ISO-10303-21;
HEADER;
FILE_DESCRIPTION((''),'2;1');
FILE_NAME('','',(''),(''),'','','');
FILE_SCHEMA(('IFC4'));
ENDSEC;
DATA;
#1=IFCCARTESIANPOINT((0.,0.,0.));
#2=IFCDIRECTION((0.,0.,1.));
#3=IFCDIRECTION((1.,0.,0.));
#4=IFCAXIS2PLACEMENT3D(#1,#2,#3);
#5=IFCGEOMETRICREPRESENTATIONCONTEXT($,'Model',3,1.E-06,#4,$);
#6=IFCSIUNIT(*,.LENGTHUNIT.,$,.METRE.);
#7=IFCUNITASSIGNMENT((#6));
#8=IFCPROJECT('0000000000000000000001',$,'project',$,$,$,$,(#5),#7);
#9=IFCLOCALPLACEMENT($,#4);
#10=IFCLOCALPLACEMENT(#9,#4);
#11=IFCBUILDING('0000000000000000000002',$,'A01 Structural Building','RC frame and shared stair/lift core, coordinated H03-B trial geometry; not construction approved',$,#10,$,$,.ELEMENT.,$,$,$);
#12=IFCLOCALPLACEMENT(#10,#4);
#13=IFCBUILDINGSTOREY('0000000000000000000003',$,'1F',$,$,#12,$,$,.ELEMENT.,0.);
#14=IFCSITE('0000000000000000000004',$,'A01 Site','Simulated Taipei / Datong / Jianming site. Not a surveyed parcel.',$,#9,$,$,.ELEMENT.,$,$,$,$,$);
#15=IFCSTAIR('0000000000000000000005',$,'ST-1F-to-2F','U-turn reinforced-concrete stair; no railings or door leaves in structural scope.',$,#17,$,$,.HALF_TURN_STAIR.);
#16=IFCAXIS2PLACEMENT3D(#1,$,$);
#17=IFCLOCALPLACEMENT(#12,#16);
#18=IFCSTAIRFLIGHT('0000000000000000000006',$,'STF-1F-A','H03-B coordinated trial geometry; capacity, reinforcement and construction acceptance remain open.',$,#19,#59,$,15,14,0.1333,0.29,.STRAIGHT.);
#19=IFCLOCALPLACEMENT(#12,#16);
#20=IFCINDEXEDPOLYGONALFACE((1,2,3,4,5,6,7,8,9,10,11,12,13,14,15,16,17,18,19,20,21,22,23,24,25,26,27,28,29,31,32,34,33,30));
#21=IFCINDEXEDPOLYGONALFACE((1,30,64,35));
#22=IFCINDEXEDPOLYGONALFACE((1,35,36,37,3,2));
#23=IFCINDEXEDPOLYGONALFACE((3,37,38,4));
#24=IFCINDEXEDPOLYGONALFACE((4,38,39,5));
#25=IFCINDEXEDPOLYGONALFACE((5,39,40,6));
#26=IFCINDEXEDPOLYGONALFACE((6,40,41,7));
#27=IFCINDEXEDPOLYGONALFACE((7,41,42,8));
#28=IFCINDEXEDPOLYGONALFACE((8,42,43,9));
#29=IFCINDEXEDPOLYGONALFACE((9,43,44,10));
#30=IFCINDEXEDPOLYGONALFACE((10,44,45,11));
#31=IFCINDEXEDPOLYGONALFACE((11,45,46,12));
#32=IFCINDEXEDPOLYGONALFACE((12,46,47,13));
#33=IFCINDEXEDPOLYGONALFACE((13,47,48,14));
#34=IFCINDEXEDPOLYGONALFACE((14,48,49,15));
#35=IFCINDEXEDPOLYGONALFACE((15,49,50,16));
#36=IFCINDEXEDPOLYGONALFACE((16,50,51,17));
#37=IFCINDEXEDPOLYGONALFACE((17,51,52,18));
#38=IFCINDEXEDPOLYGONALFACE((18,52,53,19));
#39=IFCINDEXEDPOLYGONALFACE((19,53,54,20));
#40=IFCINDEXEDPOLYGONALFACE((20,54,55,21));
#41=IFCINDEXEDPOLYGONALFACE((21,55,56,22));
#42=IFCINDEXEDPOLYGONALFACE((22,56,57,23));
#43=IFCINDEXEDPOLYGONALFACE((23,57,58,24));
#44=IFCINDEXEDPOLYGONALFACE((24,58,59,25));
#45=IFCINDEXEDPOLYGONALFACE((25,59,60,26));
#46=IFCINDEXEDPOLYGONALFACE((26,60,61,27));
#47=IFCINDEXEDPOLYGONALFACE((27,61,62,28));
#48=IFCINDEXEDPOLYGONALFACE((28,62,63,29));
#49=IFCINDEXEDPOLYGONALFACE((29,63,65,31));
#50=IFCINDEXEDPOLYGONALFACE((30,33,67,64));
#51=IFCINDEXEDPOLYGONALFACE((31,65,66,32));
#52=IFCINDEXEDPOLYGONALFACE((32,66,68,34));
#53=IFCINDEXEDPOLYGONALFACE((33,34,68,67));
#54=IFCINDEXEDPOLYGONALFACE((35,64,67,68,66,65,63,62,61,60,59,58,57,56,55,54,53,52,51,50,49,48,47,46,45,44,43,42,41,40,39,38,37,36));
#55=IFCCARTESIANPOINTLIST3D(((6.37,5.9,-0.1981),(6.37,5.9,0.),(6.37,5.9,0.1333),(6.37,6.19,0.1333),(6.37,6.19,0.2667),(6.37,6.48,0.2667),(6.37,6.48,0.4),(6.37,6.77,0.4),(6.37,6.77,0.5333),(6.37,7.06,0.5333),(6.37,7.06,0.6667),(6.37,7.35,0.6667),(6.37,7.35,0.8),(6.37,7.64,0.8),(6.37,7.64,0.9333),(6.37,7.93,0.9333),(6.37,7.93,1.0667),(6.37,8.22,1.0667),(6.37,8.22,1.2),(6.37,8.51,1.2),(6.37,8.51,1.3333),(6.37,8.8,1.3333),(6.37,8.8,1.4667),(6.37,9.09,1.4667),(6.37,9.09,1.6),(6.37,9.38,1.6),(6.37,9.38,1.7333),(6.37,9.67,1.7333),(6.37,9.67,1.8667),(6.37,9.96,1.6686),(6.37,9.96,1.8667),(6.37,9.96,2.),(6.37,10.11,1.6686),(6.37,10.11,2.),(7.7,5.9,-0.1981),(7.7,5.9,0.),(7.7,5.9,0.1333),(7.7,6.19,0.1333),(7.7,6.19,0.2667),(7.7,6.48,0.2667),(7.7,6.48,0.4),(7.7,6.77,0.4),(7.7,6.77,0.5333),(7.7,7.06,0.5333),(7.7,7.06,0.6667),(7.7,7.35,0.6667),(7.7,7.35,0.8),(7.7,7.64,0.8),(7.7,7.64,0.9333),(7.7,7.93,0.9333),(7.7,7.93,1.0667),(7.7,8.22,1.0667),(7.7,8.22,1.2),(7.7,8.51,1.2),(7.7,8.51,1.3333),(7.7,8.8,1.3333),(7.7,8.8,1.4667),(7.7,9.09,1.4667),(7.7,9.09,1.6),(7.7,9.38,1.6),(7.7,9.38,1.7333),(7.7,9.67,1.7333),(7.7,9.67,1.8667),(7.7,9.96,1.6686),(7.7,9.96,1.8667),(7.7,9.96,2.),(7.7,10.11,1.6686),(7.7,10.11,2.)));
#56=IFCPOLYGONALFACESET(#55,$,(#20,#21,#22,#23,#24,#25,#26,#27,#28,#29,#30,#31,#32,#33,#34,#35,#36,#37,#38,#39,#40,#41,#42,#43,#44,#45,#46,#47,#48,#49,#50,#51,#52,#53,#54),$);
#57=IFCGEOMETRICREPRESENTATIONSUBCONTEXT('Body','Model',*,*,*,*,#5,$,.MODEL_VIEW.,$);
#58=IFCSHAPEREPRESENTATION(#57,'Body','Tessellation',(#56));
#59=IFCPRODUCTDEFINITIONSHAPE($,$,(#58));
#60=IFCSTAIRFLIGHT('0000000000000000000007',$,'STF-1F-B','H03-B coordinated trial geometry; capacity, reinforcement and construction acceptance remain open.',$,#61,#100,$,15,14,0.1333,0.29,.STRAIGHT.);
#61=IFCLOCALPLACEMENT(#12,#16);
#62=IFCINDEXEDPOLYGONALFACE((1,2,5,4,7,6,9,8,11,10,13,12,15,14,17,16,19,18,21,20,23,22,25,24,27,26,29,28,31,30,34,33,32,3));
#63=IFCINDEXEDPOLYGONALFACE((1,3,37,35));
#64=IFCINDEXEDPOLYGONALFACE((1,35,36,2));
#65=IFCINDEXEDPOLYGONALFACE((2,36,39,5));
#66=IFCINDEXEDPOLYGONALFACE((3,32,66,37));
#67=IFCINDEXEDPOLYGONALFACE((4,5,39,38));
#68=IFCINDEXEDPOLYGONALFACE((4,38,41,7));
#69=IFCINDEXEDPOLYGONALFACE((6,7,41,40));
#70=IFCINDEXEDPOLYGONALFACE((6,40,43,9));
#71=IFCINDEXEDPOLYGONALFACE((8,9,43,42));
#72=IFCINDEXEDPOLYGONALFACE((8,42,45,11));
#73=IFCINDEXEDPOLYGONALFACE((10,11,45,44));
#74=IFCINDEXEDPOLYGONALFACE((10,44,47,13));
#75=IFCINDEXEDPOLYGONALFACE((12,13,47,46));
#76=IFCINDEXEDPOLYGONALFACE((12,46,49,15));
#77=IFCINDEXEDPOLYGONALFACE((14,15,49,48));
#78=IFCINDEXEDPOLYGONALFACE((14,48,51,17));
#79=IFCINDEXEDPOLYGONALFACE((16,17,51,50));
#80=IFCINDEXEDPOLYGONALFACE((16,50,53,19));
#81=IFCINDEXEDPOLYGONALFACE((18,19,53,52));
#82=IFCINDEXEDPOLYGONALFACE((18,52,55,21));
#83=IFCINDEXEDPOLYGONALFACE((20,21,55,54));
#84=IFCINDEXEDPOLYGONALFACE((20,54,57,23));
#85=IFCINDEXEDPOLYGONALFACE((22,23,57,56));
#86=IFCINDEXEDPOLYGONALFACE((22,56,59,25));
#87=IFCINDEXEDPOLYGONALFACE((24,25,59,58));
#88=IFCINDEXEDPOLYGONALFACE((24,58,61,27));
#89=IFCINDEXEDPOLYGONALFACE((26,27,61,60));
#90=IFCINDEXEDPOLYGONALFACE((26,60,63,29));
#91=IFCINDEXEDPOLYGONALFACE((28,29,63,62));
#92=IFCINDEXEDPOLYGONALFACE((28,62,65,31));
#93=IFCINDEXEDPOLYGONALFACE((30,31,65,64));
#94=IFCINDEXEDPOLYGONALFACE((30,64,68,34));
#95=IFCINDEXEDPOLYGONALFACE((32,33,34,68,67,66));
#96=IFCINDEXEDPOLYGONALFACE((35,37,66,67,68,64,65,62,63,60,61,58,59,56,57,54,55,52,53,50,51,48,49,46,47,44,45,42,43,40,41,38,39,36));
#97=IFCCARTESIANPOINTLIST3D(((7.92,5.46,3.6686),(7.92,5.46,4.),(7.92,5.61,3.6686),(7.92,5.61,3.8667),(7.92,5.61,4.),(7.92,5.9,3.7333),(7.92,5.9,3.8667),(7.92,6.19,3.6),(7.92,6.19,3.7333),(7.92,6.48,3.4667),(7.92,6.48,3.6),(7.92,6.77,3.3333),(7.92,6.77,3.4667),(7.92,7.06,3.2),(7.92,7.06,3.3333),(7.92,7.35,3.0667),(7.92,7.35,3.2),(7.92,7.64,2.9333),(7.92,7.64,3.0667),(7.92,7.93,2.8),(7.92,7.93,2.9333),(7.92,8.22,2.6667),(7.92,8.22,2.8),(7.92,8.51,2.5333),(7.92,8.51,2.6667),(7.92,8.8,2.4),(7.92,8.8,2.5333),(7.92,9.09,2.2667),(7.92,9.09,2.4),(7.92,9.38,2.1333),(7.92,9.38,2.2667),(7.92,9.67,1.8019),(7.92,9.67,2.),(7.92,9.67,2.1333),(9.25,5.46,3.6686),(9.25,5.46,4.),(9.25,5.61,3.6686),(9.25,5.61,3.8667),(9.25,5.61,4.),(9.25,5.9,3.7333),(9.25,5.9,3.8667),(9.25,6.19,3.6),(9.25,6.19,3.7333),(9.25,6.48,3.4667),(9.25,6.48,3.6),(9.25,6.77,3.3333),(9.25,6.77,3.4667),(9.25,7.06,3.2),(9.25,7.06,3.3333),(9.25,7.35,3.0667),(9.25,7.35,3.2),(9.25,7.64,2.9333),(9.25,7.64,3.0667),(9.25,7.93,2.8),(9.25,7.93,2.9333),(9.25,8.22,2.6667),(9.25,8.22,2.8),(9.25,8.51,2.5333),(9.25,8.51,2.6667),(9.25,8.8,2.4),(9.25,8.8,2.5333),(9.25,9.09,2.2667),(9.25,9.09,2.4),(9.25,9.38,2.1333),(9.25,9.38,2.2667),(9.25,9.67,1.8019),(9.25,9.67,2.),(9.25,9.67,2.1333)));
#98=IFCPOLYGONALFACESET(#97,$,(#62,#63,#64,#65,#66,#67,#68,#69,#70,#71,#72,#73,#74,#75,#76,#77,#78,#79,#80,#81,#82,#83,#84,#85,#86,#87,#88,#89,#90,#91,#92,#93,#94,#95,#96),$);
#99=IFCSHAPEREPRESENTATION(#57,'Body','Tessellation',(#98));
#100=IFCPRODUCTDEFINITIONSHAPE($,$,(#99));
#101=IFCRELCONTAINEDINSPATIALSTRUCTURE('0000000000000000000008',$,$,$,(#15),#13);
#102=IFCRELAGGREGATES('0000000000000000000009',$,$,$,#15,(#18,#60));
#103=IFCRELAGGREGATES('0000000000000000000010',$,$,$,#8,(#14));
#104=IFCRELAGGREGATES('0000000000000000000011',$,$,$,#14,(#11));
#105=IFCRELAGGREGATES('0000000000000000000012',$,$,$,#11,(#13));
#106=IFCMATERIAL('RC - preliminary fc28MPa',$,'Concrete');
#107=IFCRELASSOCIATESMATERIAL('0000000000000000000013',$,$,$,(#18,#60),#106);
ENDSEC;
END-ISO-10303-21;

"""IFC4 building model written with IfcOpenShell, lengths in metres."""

from ifc_helpers import new_model, si_unit, frame, origin_with_axes, place, context, subcontext, project, spatial, polyline, outline, extrude, material, element, aggregate, save


model = new_model("IFC4")

# Units and contexts
model_context = context("Model", 3, precision=1e-06, world=origin_with_axes())
body_context = subcontext(model_context, "Body", "Model", "MODEL_VIEW")
ifc_project = project(units=[si_unit("LENGTHUNIT", "METRE")], contexts=[model_context])

# Site, building, storey
site_placement = place(None, origin_with_axes())
site = spatial("IfcSite", under=ifc_project, at=site_placement, Name="A01 Site", Description="Simulated Taipei / Datong / Jianming site. Not a surveyed parcel.", CompositionType="ELEMENT")
building_placement = place(site_placement, origin_with_axes())
building = spatial("IfcBuilding", under=site, at=building_placement, Name="A01 Structural Building", Description="RC frame and shared stair/lift core, coordinated H03-B trial geometry; not construction approved", CompositionType="ELEMENT")
storey_placement = place(building_placement, origin_with_axes())
storey = spatial("IfcBuildingStorey", under=building, at=storey_placement, Name="1F", CompositionType="ELEMENT", Elevation=0.0)

# Shared definitions
ifc_material = material(Name="RC - preliminary fc28MPa", Category="Concrete")

# Stair
stair_placement = place(storey_placement, origin_with_axes())
stair = element("IfcStair", 1, at=stair_placement, inside=storey, Name="ST-1F-to-2F", Description="U-turn reinforced-concrete stair; no railings or door leaves in structural scope.", PredefinedType="HALF_TURN_STAIR")
placement = place(None, origin_with_axes())

# Stair flights
stair_flight_1 = element("IfcStairFlight", 2, at=placement, material=ifc_material, Name="STF-1F-A", Description="H03-B coordinated trial geometry; capacity, reinforcement and construction acceptance remain open.", NumberOfRisers=15, NumberOfTreads=14, PredefinedType="STRAIGHT", RiserHeight=0.1333, TreadLength=0.29, context=body_context, shape_type="SweptSolid", body=[
    extrude(outline(polyline([(0.0, 0.0), (0.0, 0.1333), (0.29, 0.1333), (0.29, 0.2667), (0.58, 0.2667), (0.58, 0.4), (0.87, 0.4), (0.87, 0.5333), (1.16, 0.5333), (1.16, 0.6667), (1.45, 0.6667), (1.45, 0.8), (1.74, 0.8), (1.74, 0.9333), (2.03, 0.9333), (2.03, 1.0667), (2.32, 1.0667), (2.32, 1.2), (2.61, 1.2), (2.61, 1.3333), (2.9, 1.3333), (2.9, 1.4667), (3.19, 1.4667), (3.19, 1.6), (3.48, 1.6), (3.48, 1.7333), (3.77, 1.7333), (3.77, 1.8667), (4.06, 1.8667), (4.06, 2.0), (4.21, 2.0), (4.21, 1.6686), (4.06, 1.6686), (0.0, -0.1981), (0.0, 0.0)])), frame((6.37, 5.9, 0.0), z_axis=(1.0, 0.0, 0.0), x_axis=(0.0, 1.0, 0.0)), (0.0, 0.0, 1.0), 1.33),
])
stair_flight_2 = element("IfcStairFlight", 3, at=placement, material=ifc_material, Name="STF-1F-B", Description="H03-B coordinated trial geometry; capacity, reinforcement and construction acceptance remain open.", NumberOfRisers=15, NumberOfTreads=14, PredefinedType="STRAIGHT", RiserHeight=0.1333, TreadLength=0.29, context=body_context, shape_type="SweptSolid", body=[
    extrude(outline(polyline([(0.0, 0.0), (0.0, 0.1333), (0.29, 0.1333), (0.29, 0.2667), (0.58, 0.2667), (0.58, 0.4), (0.87, 0.4), (0.87, 0.5333), (1.16, 0.5333), (1.16, 0.6667), (1.45, 0.6667), (1.45, 0.8), (1.74, 0.8), (1.74, 0.9333), (2.03, 0.9333), (2.03, 1.0667), (2.32, 1.0667), (2.32, 1.2), (2.61, 1.2), (2.61, 1.3333), (2.9, 1.3333), (2.9, 1.4667), (3.19, 1.4667), (3.19, 1.6), (3.48, 1.6), (3.48, 1.7333), (3.77, 1.7333), (3.77, 1.8667), (4.06, 1.8667), (4.06, 2.0), (4.21, 2.0), (4.21, 1.6686), (4.06, 1.6686), (0.0, -0.1981), (0.0, 0.0)])), frame((9.25, 9.67, 2.0), z_axis=(-1.0, 0.0, 0.0), x_axis=(0.0, -1.0, 0.0)), (0.0, 0.0, 1.0), 1.33),
])
aggregate(stair, [stair_flight_1, stair_flight_2])

save(model, "model.ifc")
